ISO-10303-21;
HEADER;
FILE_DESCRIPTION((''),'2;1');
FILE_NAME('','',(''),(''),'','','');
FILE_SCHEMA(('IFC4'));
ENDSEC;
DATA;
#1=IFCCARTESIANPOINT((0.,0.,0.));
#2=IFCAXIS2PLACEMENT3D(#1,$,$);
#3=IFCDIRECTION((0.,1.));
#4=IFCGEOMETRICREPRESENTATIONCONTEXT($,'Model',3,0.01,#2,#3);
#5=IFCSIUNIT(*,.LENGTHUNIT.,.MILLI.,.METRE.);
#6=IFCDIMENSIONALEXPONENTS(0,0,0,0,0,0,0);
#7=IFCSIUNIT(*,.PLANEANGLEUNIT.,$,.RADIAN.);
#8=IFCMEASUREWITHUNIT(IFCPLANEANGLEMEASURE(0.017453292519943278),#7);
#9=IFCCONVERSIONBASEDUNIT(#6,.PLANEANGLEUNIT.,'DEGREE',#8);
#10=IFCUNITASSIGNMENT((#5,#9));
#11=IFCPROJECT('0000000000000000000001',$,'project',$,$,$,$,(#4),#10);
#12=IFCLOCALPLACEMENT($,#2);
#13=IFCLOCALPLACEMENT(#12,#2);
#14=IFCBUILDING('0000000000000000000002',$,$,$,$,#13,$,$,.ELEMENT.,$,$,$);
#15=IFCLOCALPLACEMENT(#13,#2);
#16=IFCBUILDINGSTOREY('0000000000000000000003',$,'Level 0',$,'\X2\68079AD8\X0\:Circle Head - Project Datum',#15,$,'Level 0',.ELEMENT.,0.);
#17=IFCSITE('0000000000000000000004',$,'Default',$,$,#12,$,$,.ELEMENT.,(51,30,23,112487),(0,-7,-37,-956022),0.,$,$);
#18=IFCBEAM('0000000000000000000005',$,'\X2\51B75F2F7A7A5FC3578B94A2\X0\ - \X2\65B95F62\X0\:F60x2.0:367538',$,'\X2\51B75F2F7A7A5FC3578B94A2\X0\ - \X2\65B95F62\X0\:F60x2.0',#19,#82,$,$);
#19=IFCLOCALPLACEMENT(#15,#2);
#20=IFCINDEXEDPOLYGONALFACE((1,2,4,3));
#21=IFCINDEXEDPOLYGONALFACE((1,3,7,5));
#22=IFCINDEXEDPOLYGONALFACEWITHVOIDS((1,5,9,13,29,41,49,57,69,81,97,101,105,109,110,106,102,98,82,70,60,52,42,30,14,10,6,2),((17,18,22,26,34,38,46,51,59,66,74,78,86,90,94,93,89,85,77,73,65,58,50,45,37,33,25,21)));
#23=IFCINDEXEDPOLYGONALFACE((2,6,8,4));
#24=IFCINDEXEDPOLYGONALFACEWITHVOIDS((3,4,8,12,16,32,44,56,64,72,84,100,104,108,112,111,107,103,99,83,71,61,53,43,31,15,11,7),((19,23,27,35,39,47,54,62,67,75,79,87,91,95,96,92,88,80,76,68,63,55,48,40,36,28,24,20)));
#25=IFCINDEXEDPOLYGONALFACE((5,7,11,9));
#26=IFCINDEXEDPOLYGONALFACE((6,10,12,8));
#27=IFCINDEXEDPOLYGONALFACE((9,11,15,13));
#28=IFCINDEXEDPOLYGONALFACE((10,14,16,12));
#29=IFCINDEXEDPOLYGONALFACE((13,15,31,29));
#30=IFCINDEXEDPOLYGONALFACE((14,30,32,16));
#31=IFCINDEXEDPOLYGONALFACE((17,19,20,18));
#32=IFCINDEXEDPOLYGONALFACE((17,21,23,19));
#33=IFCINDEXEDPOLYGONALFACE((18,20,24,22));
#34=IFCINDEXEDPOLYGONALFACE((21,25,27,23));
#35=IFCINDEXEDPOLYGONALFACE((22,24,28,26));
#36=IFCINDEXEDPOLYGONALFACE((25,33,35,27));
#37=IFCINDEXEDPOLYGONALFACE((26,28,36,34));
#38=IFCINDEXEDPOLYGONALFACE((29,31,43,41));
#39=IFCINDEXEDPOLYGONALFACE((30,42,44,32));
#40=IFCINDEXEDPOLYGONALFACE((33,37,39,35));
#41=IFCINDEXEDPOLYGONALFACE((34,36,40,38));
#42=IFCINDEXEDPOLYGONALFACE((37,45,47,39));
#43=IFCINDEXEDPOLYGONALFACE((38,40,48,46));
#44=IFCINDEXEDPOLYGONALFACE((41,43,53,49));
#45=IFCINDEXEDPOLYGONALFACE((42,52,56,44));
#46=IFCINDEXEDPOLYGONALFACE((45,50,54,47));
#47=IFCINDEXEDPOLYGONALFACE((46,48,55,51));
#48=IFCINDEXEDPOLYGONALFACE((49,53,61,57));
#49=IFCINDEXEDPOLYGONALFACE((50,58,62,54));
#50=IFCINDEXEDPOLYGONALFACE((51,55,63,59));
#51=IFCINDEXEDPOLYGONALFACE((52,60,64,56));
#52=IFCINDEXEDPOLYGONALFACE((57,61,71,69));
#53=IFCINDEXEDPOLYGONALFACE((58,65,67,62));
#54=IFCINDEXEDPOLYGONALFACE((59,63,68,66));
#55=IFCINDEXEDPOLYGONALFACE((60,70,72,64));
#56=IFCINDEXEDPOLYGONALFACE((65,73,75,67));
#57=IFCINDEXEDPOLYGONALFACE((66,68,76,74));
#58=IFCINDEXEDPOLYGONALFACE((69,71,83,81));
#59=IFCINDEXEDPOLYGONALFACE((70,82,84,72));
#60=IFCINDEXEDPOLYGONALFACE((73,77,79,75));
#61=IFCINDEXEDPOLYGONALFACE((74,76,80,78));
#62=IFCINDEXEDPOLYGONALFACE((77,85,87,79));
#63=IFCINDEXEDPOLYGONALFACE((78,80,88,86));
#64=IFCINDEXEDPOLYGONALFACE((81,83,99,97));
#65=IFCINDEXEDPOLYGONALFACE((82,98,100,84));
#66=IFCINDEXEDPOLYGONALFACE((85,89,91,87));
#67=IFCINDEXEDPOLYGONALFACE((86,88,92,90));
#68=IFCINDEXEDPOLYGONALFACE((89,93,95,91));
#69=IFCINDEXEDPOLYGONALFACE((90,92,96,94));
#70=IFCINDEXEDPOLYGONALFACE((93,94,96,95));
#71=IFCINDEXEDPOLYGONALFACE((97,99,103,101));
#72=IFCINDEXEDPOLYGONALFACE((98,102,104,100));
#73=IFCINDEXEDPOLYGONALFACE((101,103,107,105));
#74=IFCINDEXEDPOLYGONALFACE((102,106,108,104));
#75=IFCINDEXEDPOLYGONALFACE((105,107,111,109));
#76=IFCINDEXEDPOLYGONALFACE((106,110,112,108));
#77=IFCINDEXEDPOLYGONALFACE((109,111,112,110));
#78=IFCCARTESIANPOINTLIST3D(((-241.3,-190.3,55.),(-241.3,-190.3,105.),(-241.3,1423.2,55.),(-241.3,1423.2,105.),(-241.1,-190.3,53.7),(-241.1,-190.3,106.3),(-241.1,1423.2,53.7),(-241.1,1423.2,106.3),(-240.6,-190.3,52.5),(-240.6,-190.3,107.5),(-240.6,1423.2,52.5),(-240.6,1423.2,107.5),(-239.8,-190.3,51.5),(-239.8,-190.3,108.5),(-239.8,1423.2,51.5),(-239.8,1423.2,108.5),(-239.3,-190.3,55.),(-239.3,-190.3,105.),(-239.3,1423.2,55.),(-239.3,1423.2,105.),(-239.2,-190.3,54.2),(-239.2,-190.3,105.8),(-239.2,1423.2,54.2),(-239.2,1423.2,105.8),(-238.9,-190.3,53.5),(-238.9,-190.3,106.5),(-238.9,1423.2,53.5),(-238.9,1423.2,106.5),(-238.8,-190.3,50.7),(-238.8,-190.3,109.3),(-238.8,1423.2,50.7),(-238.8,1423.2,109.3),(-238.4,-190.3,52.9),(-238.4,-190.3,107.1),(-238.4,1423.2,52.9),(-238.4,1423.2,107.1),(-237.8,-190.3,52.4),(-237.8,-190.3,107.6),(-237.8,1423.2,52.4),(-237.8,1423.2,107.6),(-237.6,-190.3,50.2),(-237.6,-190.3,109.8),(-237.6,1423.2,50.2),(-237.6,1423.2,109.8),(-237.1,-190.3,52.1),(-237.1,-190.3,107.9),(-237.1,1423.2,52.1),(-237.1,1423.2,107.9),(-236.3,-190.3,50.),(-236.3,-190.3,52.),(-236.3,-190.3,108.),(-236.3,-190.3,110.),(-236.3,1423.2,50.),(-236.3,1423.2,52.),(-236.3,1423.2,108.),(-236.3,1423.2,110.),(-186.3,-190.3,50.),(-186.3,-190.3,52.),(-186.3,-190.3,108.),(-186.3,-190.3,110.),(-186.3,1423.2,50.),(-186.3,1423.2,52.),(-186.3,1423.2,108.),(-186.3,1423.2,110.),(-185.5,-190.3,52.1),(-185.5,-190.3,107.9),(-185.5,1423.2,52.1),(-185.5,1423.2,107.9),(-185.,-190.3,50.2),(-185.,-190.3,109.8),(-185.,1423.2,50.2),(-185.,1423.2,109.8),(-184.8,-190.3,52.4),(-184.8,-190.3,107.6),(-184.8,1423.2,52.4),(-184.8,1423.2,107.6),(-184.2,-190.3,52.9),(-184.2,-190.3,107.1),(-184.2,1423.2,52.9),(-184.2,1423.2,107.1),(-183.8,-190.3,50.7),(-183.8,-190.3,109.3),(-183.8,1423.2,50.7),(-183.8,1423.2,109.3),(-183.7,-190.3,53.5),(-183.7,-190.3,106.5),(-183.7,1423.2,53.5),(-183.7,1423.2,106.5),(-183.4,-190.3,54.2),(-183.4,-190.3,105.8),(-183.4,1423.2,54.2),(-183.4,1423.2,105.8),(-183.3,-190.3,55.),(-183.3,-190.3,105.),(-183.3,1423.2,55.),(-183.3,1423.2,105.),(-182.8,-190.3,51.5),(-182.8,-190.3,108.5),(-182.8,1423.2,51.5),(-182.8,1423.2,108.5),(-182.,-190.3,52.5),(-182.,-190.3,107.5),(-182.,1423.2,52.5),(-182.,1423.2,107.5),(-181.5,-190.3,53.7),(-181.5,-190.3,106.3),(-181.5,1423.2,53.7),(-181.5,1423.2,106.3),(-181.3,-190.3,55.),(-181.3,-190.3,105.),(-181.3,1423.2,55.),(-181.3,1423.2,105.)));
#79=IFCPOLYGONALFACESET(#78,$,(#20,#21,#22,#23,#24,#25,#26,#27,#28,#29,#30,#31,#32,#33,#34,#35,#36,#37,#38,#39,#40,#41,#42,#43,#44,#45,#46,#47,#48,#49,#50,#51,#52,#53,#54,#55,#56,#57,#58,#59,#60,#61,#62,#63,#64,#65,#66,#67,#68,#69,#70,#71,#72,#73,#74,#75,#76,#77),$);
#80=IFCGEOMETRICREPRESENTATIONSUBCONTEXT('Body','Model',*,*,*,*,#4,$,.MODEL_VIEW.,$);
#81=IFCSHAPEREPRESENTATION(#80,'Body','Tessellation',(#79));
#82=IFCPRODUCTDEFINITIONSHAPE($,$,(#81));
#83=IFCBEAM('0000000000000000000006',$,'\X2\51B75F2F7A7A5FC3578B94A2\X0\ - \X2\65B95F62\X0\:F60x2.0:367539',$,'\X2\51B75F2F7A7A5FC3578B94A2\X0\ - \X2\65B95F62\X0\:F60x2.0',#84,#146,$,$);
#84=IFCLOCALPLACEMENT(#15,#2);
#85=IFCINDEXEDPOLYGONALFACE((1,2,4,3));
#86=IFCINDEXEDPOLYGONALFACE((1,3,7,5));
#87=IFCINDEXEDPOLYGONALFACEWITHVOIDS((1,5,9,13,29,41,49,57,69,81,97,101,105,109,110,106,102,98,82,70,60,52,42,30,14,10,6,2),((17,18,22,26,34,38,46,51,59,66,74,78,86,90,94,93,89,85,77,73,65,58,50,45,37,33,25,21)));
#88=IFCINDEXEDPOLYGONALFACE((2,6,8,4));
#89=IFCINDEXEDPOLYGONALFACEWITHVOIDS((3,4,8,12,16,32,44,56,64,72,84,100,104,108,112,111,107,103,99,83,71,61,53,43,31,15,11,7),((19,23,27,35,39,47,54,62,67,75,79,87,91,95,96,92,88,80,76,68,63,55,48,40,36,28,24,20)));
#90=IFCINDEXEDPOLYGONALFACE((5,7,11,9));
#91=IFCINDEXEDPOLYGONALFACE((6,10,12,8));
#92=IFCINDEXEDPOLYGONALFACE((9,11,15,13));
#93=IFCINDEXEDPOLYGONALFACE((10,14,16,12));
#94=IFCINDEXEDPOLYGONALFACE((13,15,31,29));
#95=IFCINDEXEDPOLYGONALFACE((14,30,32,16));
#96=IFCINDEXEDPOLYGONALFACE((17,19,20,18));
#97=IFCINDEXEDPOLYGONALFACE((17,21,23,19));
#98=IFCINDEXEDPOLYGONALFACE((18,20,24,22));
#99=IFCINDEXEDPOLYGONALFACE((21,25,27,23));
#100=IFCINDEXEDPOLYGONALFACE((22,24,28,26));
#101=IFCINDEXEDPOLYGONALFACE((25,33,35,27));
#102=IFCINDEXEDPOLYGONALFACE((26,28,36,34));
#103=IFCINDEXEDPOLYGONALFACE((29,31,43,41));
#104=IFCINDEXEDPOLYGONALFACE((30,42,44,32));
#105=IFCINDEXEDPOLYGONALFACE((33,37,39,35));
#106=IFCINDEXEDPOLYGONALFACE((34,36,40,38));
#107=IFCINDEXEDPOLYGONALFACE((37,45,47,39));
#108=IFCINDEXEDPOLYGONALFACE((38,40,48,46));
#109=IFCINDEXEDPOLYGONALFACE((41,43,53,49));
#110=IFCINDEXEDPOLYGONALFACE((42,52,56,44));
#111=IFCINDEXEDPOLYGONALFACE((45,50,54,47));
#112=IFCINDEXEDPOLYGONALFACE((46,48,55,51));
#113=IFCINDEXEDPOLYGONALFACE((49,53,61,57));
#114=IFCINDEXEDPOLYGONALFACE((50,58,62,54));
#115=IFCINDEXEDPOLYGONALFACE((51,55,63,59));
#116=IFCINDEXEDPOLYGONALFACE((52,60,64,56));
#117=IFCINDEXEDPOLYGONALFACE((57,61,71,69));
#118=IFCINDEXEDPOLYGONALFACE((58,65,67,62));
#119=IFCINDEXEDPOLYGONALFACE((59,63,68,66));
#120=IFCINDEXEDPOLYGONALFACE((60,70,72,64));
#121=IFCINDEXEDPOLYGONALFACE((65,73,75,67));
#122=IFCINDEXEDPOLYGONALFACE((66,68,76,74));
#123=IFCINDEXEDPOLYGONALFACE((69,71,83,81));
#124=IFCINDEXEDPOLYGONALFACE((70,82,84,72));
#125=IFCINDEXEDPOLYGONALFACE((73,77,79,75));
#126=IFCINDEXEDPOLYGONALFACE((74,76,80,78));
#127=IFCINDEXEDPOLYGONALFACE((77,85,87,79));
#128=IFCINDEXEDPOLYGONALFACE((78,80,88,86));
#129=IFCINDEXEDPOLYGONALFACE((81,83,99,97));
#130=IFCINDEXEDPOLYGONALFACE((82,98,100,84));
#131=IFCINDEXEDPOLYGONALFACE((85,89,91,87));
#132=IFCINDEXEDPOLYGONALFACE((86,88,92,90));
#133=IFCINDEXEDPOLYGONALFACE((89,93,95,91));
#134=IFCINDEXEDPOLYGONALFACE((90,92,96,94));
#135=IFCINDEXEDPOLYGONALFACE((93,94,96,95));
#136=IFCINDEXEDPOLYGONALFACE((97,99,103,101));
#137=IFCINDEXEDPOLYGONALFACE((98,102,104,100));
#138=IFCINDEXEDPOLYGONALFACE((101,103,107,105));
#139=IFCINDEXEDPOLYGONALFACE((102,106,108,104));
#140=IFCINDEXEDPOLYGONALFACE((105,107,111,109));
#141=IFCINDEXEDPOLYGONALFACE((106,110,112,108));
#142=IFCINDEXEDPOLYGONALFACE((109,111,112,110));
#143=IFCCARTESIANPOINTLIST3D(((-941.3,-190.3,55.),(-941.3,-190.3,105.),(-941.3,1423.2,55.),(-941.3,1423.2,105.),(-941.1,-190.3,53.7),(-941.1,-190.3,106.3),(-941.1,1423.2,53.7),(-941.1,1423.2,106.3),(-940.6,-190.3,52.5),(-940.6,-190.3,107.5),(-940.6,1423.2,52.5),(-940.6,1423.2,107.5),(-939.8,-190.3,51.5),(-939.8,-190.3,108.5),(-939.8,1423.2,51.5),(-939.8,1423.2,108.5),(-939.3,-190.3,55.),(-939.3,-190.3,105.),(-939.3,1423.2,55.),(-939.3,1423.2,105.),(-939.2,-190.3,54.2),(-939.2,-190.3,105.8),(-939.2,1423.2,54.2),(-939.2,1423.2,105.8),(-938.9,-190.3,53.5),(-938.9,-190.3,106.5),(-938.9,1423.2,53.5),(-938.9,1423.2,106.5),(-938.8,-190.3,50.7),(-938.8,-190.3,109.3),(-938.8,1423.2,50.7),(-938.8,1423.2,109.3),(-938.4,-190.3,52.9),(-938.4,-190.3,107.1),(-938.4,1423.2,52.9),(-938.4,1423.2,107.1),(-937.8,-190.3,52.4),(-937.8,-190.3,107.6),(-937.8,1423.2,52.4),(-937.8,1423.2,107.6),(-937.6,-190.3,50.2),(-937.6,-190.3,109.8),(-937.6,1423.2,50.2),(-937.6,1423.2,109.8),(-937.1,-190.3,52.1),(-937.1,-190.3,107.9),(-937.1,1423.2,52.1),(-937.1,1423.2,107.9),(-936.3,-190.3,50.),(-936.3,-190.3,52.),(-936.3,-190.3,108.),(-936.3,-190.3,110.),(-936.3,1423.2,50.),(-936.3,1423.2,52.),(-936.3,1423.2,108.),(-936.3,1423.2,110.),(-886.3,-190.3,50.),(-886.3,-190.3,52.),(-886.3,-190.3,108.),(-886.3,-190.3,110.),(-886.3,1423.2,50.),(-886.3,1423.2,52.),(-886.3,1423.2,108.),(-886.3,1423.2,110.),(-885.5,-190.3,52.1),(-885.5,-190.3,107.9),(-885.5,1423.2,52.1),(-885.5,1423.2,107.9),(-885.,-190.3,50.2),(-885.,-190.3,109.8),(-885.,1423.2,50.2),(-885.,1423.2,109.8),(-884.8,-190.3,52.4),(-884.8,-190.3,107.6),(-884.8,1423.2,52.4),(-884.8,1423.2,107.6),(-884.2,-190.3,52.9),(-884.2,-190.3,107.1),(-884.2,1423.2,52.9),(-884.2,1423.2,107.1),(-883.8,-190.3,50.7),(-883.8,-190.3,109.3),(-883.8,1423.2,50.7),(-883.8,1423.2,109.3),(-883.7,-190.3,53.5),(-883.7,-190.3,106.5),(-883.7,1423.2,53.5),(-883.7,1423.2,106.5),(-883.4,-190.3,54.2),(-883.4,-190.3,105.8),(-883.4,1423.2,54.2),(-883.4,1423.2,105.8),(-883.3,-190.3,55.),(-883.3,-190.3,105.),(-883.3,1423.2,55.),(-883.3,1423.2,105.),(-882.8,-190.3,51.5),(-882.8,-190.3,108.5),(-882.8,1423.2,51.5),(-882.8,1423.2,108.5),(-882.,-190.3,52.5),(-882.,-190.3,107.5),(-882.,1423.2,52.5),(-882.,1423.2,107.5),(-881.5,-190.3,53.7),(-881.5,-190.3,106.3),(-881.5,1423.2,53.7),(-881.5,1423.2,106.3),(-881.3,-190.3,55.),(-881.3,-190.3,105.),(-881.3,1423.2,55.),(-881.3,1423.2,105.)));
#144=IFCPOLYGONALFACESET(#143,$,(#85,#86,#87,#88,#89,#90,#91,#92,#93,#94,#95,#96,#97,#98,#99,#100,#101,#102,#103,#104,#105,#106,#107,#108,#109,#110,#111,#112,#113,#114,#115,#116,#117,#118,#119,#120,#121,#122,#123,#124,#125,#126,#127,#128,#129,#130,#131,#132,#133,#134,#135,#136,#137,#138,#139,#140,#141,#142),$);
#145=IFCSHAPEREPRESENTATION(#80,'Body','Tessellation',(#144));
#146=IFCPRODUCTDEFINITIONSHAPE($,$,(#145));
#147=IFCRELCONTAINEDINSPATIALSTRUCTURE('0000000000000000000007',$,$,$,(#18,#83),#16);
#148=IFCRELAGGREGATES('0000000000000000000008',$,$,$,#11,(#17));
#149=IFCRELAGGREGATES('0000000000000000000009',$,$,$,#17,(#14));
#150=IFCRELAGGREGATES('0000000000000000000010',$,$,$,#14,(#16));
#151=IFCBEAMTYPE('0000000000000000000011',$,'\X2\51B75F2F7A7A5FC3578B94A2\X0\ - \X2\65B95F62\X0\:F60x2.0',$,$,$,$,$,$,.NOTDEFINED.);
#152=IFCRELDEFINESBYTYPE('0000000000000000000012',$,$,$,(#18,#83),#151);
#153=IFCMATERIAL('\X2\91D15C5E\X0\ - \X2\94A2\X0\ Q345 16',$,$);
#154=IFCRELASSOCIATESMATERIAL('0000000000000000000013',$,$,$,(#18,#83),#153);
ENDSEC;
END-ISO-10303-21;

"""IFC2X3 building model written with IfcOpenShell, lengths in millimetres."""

from ifc_helpers import new_model, entity, si_unit, converted_unit, direction, frame, frame_2d, origin, place, context, subcontext, project, spatial, polyline, circle_curve, parameter, trimmed, segment, composite_curve, outline, extrude, material, type_object, element, save


model = new_model("IFC2X3")

# Units and contexts
model_context = context("Model", 3, precision=0.01, world=origin(), true_north=direction((0.0, 1.0)))
body_context = subcontext(model_context, "Body", "Model", "MODEL_VIEW")
ifc_project = project(units=[si_unit("LENGTHUNIT", "METRE", prefix="MILLI"), converted_unit("PLANEANGLEUNIT", "DEGREE", entity("IfcPlaneAngleMeasure", 0.017453292519943278), si_unit("PLANEANGLEUNIT", "RADIAN"), dimensions=[0, 0, 0, 0, 0, 0, 0])], contexts=[model_context])

# Site, building, storey
site_placement = place(None, origin())
site = spatial("IfcSite", under=ifc_project, at=site_placement, Name="Default", CompositionType="ELEMENT", RefLatitude=(51, 30, 23, 112487), RefLongitude=(0, -7, -37, -956022), RefElevation=0.0)
building_placement = place(site_placement, origin())
building = spatial("IfcBuilding", under=site, at=building_placement, CompositionType="ELEMENT")
storey_placement = place(building_placement, origin())
storey = spatial("IfcBuildingStorey", under=building, at=storey_placement, Name="Level 0", ObjectType="标高:Circle Head - Project Datum", LongName="Level 0", CompositionType="ELEMENT", Elevation=0.0)

# Beams
ifc_material_1 = material(Name="金属 - 钢 Q345 16")
beam_type_1 = type_object("IfcBeamType", Name="冷弯空心型钢 - 方形:F60x2.0", PredefinedType="NOTDEFINED")
beam_1_placement = place(storey_placement, frame((-211.3, 1388.1, 110.0), z_axis=(0.0, 0.0, 1.0), x_axis=(0.0, -1.0, 0.0)))
element("IfcBeam", 1, at=beam_1_placement, inside=storey, type_object=beam_type_1, material=ifc_material_1, Name="冷弯空心型钢 - 方形:F60x2.0:367538", ObjectType="冷弯空心型钢 - 方形:F60x2.0", context=body_context, shape_type="SweptSolid", body=[
    extrude(outline(composite_curve([segment(trimmed(circle_curve(frame_2d((-25.0, 25.0), x_axis=(1.0, 0.0)), 5.0), [parameter(90.0)], [parameter(180.0)], True, "PARAMETER"), True, "CONTINUOUS"), segment(polyline([(-30.0, 25.0), (-30.0, -25.0)]), True, "CONTINUOUS"), segment(trimmed(circle_curve(frame_2d((-25.0, -25.0), x_axis=(1.0, 0.0)), 5.0), [parameter(180.0)], [parameter(270.0)], True, "PARAMETER"), True, "CONTINUOUS"), segment(polyline([(-25.0, -30.0), (25.0, -30.0)]), True, "CONTINUOUS"), segment(trimmed(circle_curve(frame_2d((25.0, -25.0), x_axis=(1.0, 0.0)), 5.0), [parameter(270.0)], [parameter(0.0)], True, "PARAMETER"), True, "CONTINUOUS"), segment(polyline([(30.0, -25.0), (30.0, 25.0)]), True, "CONTINUOUS"), segment(trimmed(circle_curve(frame_2d((25.0, 25.0), x_axis=(1.0, 0.0)), 5.0), [parameter(0.0)], [parameter(90.0)], True, "PARAMETER"), True, "CONTINUOUS"), segment(polyline([(25.0, 30.0), (-25.0, 30.0)]), True, "CONTINUOUS")], self_intersect=False), holes=[composite_curve([segment(polyline([(-25.0, 28.0), (25.0, 28.0)]), True, "CONTINUOUS"), segment(trimmed(circle_curve(frame_2d((25.0, 25.0), x_axis=(1.0, 0.0)), 3.0), [parameter(0.0)], [parameter(90.0)], True, "PARAMETER"), False, "CONTINUOUS"), segment(polyline([(28.0, 25.0), (28.0, -25.0)]), True, "CONTINUOUS"), segment(trimmed(circle_curve(frame_2d((25.0, -25.0), x_axis=(1.0, 0.0)), 3.0), [parameter(270.0)], [parameter(360.0)], True, "PARAMETER"), False, "CONTINUOUS"), segment(polyline([(25.0, -28.0), (-25.0, -28.0)]), True, "CONTINUOUS"), segment(trimmed(circle_curve(frame_2d((-25.0, -25.0), x_axis=(1.0, 0.0)), 3.0), [parameter(180.0)], [parameter(270.0)], True, "PARAMETER"), False, "CONTINUOUS"), segment(polyline([(-28.0, -25.0), (-28.0, 25.0)]), True, "CONTINUOUS"), segment(trimmed(circle_curve(frame_2d((-25.0, 25.0), x_axis=(1.0, 0.0)), 3.0), [parameter(90.0)], [parameter(180.0)], True, "PARAMETER"), False, "CONTINUOUS")], self_intersect=False)]), frame((-35.1, 0.0, -30.0), z_axis=(1.0, 0.0, 0.0), x_axis=(0.0, 1.0, 0.0)), (0.0, 0.0, 1.0), 1613.5),
])
beam_2_placement = place(storey_placement, frame((-911.3, 1388.1, 110.0), z_axis=(0.0, 0.0, 1.0), x_axis=(0.0, -1.0, 0.0)))
element("IfcBeam", 2, at=beam_2_placement, inside=storey, type_object=beam_type_1, material=ifc_material_1, Name="冷弯空心型钢 - 方形:F60x2.0:367539", ObjectType="冷弯空心型钢 - 方形:F60x2.0", context=body_context, shape_type="SweptSolid", body=[
    extrude(outline(composite_curve([segment(trimmed(circle_curve(frame_2d((-25.0, 25.0), x_axis=(1.0, 0.0)), 5.0), [parameter(90.0)], [parameter(180.0)], True, "PARAMETER"), True, "CONTINUOUS"), segment(polyline([(-30.0, 25.0), (-30.0, -25.0)]), True, "CONTINUOUS"), segment(trimmed(circle_curve(frame_2d((-25.0, -25.0), x_axis=(1.0, 0.0)), 5.0), [parameter(180.0)], [parameter(270.0)], True, "PARAMETER"), True, "CONTINUOUS"), segment(polyline([(-25.0, -30.0), (25.0, -30.0)]), True, "CONTINUOUS"), segment(trimmed(circle_curve(frame_2d((25.0, -25.0), x_axis=(1.0, 0.0)), 5.0), [parameter(270.0)], [parameter(0.0)], True, "PARAMETER"), True, "CONTINUOUS"), segment(polyline([(30.0, -25.0), (30.0, 25.0)]), True, "CONTINUOUS"), segment(trimmed(circle_curve(frame_2d((25.0, 25.0), x_axis=(1.0, 0.0)), 5.0), [parameter(0.0)], [parameter(90.0)], True, "PARAMETER"), True, "CONTINUOUS"), segment(polyline([(25.0, 30.0), (-25.0, 30.0)]), True, "CONTINUOUS")], self_intersect=False), holes=[composite_curve([segment(polyline([(-25.0, 28.0), (25.0, 28.0)]), True, "CONTINUOUS"), segment(trimmed(circle_curve(frame_2d((25.0, 25.0), x_axis=(1.0, 0.0)), 3.0), [parameter(0.0)], [parameter(90.0)], True, "PARAMETER"), False, "CONTINUOUS"), segment(polyline([(28.0, 25.0), (28.0, -25.0)]), True, "CONTINUOUS"), segment(trimmed(circle_curve(frame_2d((25.0, -25.0), x_axis=(1.0, 0.0)), 3.0), [parameter(270.0)], [parameter(360.0)], True, "PARAMETER"), False, "CONTINUOUS"), segment(polyline([(25.0, -28.0), (-25.0, -28.0)]), True, "CONTINUOUS"), segment(trimmed(circle_curve(frame_2d((-25.0, -25.0), x_axis=(1.0, 0.0)), 3.0), [parameter(180.0)], [parameter(270.0)], True, "PARAMETER"), False, "CONTINUOUS"), segment(polyline([(-28.0, -25.0), (-28.0, 25.0)]), True, "CONTINUOUS"), segment(trimmed(circle_curve(frame_2d((-25.0, 25.0), x_axis=(1.0, 0.0)), 3.0), [parameter(90.0)], [parameter(180.0)], True, "PARAMETER"), False, "CONTINUOUS")], self_intersect=False)]), frame((-35.1, 0.0, -30.0), z_axis=(1.0, 0.0, 0.0), x_axis=(0.0, 1.0, 0.0)), (0.0, 0.0, 1.0), 1613.5),
])

save(model, "model.ifc")
